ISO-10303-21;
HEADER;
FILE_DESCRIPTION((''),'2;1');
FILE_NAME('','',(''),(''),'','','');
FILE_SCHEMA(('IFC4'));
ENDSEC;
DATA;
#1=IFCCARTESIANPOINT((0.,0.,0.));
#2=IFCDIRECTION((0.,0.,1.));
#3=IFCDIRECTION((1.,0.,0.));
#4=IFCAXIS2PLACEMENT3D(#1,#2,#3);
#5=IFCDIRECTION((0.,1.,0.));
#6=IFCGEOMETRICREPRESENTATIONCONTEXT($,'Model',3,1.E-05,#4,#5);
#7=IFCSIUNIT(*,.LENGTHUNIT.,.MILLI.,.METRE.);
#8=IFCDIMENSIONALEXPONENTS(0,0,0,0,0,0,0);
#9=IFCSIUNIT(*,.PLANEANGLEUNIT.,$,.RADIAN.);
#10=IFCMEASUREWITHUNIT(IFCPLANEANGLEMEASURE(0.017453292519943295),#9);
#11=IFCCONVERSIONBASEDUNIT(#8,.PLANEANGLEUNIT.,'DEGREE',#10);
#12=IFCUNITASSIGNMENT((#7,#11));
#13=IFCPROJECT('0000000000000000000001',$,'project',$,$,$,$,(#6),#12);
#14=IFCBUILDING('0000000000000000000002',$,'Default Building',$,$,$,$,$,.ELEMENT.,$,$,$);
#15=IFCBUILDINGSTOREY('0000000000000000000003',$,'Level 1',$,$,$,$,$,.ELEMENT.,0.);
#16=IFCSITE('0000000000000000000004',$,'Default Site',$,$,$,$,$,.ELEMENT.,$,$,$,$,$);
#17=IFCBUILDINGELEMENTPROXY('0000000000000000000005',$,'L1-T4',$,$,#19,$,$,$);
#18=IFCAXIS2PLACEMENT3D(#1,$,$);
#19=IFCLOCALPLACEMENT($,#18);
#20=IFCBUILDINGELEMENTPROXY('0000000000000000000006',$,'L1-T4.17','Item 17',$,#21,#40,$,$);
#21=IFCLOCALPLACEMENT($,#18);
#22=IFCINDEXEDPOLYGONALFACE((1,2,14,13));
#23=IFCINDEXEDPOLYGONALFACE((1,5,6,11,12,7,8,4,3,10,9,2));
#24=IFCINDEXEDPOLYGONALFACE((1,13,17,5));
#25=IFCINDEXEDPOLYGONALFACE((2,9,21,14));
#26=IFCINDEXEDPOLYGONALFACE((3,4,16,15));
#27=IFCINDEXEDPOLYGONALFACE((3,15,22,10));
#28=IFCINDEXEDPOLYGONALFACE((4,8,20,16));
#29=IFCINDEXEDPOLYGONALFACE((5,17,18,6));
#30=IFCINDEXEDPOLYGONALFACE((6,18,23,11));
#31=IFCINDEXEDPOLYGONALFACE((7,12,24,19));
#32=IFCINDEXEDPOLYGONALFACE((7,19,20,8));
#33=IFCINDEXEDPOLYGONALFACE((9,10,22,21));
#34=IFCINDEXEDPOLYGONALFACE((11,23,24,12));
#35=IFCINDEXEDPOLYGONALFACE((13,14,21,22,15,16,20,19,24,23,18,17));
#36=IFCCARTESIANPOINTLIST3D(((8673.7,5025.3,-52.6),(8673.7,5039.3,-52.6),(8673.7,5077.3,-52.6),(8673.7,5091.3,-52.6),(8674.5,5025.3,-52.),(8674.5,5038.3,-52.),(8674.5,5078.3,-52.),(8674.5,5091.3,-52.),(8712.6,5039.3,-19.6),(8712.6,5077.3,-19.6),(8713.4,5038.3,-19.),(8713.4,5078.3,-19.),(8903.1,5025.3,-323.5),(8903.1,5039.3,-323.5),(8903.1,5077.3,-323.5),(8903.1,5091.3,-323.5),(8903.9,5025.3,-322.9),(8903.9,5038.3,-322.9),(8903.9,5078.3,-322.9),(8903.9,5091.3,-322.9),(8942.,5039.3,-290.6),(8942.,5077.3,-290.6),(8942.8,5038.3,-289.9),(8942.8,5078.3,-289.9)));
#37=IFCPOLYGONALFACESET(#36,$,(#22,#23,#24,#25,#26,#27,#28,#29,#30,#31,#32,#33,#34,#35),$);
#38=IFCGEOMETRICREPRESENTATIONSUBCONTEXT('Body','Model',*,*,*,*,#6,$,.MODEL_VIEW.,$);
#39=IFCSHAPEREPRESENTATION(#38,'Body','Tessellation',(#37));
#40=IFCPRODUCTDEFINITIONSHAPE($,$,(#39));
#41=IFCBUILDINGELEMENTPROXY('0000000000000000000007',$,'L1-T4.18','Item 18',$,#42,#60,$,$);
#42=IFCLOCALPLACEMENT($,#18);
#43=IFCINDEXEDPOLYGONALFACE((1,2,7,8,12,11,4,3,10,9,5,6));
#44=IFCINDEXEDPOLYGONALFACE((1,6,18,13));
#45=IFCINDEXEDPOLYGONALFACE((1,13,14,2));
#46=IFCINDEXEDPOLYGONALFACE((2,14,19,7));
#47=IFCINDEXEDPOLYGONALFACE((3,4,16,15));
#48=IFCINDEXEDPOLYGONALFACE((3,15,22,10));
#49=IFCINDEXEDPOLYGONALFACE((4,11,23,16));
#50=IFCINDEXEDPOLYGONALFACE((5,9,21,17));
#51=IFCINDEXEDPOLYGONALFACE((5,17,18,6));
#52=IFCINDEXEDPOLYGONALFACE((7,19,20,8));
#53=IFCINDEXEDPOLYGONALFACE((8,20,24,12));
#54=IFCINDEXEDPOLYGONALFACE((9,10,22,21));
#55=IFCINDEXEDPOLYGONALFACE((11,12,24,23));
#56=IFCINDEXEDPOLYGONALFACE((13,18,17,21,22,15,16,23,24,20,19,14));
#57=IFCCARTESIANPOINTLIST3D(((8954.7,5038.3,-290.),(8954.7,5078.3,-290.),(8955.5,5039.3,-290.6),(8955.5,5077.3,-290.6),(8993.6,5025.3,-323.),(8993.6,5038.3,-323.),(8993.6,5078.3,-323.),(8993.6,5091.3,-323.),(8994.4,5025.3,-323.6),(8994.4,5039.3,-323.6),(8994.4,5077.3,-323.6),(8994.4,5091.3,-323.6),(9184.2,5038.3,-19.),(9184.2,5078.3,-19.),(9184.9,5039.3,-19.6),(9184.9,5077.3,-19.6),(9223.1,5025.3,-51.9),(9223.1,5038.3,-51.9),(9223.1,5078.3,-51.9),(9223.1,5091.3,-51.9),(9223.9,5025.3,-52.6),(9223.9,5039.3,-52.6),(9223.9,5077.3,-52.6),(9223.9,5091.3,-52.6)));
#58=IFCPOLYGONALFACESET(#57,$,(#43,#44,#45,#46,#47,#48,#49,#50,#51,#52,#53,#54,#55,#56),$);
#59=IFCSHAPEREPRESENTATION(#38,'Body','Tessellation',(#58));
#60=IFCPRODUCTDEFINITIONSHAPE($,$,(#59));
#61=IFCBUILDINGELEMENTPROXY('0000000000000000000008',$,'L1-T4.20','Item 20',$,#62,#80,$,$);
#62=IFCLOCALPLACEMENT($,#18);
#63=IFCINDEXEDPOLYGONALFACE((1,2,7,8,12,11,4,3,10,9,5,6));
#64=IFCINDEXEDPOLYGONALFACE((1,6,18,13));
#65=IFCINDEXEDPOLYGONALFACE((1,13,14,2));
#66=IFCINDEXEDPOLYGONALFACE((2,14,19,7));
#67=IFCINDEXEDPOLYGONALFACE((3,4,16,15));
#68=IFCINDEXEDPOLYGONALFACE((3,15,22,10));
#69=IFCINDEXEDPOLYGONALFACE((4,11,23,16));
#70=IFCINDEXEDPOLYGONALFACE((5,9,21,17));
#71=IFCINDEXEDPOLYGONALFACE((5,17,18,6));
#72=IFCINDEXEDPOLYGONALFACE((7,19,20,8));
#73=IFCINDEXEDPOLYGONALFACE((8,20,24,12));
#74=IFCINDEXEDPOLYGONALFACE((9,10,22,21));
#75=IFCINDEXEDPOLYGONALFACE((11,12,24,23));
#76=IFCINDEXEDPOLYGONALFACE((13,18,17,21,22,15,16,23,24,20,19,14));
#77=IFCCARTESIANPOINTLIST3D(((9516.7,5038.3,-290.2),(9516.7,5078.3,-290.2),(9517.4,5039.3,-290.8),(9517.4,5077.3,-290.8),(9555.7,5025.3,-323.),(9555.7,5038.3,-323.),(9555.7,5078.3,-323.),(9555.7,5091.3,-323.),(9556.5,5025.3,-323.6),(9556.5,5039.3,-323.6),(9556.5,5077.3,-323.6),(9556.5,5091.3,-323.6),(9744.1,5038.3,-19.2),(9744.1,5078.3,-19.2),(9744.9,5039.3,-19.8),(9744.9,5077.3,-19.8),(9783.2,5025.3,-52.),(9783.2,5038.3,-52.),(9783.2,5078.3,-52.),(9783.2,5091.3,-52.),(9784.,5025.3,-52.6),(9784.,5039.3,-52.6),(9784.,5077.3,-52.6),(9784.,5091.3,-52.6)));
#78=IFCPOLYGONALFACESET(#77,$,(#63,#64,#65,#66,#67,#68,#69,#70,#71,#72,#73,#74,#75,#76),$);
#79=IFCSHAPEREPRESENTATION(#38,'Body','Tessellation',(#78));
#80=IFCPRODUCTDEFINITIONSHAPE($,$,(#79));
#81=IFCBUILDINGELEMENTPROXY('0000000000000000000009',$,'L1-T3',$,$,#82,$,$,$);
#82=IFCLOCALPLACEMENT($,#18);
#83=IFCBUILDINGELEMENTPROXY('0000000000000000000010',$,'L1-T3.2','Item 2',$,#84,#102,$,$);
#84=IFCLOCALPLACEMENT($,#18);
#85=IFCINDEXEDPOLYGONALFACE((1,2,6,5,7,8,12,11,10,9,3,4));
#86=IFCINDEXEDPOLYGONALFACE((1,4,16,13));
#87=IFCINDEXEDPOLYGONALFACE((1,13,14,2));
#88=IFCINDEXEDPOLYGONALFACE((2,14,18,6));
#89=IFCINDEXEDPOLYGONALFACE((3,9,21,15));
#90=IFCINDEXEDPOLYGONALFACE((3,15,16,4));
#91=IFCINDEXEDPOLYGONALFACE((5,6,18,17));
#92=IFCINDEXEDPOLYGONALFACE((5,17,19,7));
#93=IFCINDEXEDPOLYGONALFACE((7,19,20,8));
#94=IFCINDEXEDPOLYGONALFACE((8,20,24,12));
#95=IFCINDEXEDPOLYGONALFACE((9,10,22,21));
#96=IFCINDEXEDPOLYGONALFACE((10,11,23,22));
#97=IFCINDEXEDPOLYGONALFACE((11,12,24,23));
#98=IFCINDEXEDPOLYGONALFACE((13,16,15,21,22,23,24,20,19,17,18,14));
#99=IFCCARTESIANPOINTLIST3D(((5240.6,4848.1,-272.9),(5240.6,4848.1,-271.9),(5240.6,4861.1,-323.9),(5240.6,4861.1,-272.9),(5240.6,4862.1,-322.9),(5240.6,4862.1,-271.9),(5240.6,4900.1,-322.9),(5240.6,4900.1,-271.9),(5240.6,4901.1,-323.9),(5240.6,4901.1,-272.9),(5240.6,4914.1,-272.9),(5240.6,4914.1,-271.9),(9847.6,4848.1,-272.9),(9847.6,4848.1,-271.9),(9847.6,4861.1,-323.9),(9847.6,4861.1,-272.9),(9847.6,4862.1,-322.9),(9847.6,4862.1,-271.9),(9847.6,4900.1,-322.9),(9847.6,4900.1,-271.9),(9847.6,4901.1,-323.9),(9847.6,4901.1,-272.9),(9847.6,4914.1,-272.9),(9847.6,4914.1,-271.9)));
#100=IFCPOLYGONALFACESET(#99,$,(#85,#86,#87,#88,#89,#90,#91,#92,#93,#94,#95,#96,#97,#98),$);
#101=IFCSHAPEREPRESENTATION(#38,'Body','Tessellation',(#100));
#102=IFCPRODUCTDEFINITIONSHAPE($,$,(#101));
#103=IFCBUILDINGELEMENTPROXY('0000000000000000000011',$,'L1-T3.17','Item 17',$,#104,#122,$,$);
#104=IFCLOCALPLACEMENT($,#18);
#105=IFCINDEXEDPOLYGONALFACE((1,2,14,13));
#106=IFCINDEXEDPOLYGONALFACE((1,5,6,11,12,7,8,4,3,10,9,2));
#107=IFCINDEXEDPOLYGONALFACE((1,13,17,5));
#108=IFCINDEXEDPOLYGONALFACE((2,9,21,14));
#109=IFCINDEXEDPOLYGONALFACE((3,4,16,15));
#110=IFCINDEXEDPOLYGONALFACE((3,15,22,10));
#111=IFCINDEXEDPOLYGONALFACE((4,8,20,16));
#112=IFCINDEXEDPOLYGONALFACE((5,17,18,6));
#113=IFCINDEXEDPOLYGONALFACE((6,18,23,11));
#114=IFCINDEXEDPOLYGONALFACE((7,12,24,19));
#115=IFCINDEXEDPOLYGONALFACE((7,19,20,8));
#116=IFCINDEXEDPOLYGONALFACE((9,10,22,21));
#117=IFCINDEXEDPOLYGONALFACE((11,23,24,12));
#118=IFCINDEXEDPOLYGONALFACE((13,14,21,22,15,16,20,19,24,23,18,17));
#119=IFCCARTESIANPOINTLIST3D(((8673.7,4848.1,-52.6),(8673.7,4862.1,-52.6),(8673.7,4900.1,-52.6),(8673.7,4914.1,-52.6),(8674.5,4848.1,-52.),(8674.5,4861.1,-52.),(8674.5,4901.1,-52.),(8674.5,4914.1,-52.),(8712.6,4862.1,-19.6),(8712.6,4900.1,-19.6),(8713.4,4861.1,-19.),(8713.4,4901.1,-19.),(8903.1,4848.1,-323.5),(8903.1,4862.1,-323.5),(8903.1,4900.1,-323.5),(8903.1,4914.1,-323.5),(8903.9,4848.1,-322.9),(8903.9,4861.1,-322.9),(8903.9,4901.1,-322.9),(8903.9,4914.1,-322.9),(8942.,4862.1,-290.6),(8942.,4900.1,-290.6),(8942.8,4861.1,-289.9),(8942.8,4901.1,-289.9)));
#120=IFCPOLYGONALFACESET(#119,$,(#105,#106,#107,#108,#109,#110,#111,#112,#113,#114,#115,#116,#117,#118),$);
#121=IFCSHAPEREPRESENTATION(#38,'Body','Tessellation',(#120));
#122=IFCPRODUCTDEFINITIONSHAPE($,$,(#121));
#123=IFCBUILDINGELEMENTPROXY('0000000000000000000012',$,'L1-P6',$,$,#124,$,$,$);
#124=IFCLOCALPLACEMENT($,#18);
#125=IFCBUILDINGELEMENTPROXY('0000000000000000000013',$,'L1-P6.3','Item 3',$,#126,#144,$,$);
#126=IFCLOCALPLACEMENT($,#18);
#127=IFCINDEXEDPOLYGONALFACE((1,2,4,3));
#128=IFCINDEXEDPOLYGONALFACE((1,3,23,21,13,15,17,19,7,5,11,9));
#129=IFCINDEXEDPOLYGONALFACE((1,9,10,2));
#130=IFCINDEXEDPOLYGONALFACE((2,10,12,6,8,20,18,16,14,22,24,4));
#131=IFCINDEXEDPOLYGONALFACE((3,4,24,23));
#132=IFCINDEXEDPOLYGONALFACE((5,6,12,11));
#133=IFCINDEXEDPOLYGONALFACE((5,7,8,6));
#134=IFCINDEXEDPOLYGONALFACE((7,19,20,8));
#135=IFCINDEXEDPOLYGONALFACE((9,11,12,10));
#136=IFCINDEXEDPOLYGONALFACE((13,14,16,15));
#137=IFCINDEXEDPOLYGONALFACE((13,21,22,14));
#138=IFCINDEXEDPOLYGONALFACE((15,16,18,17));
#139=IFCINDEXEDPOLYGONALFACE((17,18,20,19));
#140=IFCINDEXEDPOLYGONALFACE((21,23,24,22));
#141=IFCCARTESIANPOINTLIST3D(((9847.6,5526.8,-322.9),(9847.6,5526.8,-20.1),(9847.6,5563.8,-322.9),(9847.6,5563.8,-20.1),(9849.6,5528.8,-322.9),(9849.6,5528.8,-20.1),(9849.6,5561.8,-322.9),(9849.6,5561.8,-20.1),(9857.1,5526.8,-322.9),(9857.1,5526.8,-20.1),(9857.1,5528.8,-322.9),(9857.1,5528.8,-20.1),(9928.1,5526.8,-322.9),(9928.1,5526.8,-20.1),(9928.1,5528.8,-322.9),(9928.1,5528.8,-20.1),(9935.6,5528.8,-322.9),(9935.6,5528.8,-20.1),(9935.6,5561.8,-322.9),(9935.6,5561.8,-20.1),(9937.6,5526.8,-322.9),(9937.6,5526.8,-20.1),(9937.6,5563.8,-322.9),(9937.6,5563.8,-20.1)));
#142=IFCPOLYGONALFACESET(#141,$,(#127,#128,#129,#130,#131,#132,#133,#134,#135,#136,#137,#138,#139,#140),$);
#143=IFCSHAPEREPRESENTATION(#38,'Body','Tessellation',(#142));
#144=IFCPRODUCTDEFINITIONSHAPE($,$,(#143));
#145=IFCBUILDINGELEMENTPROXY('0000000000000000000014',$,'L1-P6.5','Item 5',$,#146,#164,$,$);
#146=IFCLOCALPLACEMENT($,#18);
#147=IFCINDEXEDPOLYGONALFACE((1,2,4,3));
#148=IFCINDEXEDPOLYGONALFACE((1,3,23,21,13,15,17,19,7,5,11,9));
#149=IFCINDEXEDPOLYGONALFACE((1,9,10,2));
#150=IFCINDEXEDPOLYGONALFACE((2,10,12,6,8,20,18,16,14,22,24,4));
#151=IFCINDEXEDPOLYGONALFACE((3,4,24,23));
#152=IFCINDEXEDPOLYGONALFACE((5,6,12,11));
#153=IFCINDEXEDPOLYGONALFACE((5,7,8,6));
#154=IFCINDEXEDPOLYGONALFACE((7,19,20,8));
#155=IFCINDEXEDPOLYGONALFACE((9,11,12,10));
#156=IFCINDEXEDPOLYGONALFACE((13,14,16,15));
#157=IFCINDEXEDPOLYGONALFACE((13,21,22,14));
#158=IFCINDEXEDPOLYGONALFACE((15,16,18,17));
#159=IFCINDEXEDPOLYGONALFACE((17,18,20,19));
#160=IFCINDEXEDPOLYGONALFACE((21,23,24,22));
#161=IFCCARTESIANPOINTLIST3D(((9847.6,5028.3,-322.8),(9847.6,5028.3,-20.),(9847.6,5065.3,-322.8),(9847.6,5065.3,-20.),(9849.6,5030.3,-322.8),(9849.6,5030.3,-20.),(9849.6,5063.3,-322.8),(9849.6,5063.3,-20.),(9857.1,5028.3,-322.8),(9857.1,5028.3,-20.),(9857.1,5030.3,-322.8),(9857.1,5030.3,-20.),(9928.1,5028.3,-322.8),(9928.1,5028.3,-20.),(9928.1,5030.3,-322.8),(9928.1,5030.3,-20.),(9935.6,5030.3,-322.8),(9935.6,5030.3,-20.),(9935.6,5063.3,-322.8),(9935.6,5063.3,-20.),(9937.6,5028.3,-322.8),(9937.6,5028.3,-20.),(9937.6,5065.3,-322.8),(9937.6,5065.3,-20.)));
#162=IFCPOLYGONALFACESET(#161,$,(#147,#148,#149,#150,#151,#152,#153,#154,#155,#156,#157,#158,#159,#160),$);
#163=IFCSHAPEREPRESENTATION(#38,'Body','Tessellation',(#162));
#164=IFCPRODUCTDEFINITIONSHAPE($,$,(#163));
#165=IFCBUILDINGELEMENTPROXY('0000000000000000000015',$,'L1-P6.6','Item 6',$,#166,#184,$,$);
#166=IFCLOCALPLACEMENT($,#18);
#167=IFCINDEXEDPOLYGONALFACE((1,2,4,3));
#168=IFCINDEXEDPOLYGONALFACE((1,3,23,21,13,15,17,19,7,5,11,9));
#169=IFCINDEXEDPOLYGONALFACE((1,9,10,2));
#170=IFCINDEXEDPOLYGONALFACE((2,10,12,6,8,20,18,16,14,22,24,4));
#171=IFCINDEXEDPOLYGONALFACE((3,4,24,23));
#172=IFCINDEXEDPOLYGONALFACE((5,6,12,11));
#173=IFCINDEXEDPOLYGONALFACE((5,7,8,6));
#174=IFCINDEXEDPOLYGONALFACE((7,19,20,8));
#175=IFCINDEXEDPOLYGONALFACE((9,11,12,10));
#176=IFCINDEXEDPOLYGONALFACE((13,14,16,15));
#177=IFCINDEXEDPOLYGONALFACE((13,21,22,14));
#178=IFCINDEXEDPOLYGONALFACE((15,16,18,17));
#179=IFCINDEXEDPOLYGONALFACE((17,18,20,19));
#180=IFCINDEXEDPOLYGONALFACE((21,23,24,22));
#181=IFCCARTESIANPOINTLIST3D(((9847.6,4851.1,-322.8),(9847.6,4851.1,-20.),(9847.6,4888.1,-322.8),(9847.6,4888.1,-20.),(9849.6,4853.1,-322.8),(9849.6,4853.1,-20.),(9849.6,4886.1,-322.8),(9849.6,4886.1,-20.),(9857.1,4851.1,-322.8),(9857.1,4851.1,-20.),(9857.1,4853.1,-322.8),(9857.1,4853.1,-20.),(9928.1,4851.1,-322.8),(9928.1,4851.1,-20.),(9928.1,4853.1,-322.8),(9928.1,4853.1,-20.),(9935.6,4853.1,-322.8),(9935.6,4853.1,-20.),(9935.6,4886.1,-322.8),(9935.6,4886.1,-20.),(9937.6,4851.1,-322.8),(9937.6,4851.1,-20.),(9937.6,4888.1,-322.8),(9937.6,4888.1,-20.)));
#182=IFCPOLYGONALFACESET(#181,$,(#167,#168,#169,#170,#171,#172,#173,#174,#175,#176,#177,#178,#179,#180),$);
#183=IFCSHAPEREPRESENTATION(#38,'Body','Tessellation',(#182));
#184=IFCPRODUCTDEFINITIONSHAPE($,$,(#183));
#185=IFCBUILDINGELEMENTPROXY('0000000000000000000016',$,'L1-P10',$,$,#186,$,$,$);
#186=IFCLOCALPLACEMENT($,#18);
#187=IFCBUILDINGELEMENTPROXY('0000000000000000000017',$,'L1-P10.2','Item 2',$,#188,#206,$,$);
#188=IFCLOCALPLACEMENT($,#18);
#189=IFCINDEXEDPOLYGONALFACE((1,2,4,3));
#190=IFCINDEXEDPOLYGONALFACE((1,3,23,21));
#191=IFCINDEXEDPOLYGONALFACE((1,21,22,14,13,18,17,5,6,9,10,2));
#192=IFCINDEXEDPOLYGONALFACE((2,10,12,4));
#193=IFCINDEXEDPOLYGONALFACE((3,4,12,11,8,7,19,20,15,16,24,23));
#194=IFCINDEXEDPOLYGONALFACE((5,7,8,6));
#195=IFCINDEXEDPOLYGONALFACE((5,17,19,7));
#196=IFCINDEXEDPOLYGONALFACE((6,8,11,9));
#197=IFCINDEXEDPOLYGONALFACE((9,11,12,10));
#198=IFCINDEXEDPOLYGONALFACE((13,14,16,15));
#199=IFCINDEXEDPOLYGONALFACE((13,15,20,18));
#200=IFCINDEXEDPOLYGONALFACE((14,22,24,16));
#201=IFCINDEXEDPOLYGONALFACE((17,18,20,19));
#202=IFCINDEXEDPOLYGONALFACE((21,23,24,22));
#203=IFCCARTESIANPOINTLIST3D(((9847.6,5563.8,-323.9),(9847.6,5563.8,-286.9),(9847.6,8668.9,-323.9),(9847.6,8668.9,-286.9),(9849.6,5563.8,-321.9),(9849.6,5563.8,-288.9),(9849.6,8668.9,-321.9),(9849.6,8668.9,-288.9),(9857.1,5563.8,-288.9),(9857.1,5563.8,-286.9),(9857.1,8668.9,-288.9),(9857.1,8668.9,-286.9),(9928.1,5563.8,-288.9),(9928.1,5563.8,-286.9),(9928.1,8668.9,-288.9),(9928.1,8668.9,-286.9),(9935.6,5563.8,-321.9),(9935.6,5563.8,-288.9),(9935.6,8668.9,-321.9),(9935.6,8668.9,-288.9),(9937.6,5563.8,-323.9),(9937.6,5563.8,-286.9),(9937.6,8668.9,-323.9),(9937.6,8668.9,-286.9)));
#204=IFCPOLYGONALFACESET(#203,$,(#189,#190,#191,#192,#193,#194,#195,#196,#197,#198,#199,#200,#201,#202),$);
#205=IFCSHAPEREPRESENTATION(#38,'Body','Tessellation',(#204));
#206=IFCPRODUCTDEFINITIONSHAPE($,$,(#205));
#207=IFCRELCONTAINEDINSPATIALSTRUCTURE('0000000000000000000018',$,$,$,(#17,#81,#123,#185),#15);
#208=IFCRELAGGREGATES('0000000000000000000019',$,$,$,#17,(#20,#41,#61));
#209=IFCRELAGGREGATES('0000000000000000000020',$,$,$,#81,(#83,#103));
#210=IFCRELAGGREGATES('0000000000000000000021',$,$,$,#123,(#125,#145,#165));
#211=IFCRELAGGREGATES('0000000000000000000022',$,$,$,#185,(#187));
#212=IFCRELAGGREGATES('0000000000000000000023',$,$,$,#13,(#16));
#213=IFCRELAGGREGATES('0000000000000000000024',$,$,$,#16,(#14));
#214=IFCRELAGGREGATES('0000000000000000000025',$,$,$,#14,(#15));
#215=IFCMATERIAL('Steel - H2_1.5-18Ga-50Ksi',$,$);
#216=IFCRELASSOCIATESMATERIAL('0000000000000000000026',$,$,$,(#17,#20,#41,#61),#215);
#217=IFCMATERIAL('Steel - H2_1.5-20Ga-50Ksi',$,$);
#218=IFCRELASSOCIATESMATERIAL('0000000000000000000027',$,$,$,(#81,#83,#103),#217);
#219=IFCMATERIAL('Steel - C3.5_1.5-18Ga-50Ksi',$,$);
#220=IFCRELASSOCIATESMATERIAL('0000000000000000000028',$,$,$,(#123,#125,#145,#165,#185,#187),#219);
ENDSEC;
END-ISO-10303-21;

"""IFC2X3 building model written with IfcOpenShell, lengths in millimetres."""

from ifc_helpers import new_model, entity, si_unit, converted_unit, direction, frame, origin, origin_with_axes, origin_2d_with_axis, place, context, subcontext, project, spatial, polyline, c_section, outline, extrude, material, element, aggregate, save


model = new_model("IFC2X3")

# Units and contexts
model_context = context("Model", 3, precision=1e-05, world=origin_with_axes(), true_north=direction((0.0, 1.0, 0.0)))
body_context = subcontext(model_context, "Body", "Model", "MODEL_VIEW")
ifc_project = project(units=[si_unit("LENGTHUNIT", "METRE", prefix="MILLI"), converted_unit("PLANEANGLEUNIT", "DEGREE", entity("IfcPlaneAngleMeasure", 0.017453292519943295), si_unit("PLANEANGLEUNIT", "RADIAN"), dimensions=[0, 0, 0, 0, 0, 0, 0])], contexts=[model_context])

# Site, building, storey
site = spatial("IfcSite", under=ifc_project, Name="Default Site", CompositionType="ELEMENT")
building = spatial("IfcBuilding", under=site, Name="Default Building", CompositionType="ELEMENT")
storey = spatial("IfcBuildingStorey", under=building, Name="Level 1", CompositionType="ELEMENT", Elevation=0.0)

# Building element proxies
ifc_material_1 = material(Name="Steel - H2_1.5-20Ga-50Ksi")
ifc_material_2 = material(Name="Steel - H2_1.5-18Ga-50Ksi")
proxy_1 = element("IfcBuildingElementProxy", 1, inside=storey, material=ifc_material_2, Name="L1-T4")
proxy_2_placement = place(None, frame((8673.7, 5025.3, -52.6), z_axis=(0.646, 0.0, -0.763), x_axis=(0.0, 40.0, 0.0)))
proxy_2 = element("IfcBuildingElementProxy", 2, at=proxy_2_placement, material=ifc_material_2, Name="L1-T4.17", Description="Item 17", context=body_context, shape_type="SweptSolid", body=[
    extrude(outline(polyline([(0.0, 0.0), (14.0, 0.0), (14.0, 51.0), (52.0, 51.0), (52.0, 0.0), (66.0, 0.0), (66.0, 1.0), (53.0, 1.0), (53.0, 52.0), (13.0, 52.0), (13.0, 1.0), (0.0, 1.0), (0.0, 0.0)])), origin(), (0.0, 0.0, 1.0), 355.0),
])
proxy_3_placement = place(None, frame((8994.4, 5025.3, -323.6), z_axis=(0.646, 0.0, 0.763), x_axis=(0.0, 40.0, 0.0)))
proxy_3 = element("IfcBuildingElementProxy", 3, at=proxy_3_placement, material=ifc_material_2, Name="L1-T4.18", Description="Item 18", context=body_context, shape_type="SweptSolid", body=[
    extrude(outline(polyline([(0.0, 0.0), (14.0, 0.0), (14.0, 51.0), (52.0, 51.0), (52.0, 0.0), (66.0, 0.0), (66.0, 1.0), (53.0, 1.0), (53.0, 52.0), (13.0, 52.0), (13.0, 1.0), (0.0, 1.0), (0.0, 0.0)])), origin(), (0.0, 0.0, 1.0), 355.1),
])
proxy_4_placement = place(None, frame((9556.5, 5025.3, -323.6), z_axis=(0.643, 0.0, 0.766), x_axis=(0.0, 40.0, 0.0)))
proxy_4 = element("IfcBuildingElementProxy", 4, at=proxy_4_placement, material=ifc_material_2, Name="L1-T4.20", Description="Item 20", context=body_context, shape_type="SweptSolid", body=[
    extrude(outline(polyline([(0.0, 0.0), (14.0, 0.0), (14.0, 51.0), (52.0, 51.0), (52.0, 0.0), (66.0, 0.0), (66.0, 1.0), (53.0, 1.0), (53.0, 52.0), (13.0, 52.0), (13.0, 1.0), (0.0, 1.0), (0.0, 0.0)])), origin(), (0.0, 0.0, 1.0), 353.8),
])
aggregate(proxy_1, [proxy_2, proxy_3, proxy_4])
proxy_5 = element("IfcBuildingElementProxy", 5, inside=storey, material=ifc_material_1, Name="L1-T3")
proxy_6_placement = place(None, frame((9847.6, 4848.1, -271.9), z_axis=(-1.0, 0.0, 0.0), x_axis=(0.0, 40.0, 0.0)))
proxy_6 = element("IfcBuildingElementProxy", 6, at=proxy_6_placement, material=ifc_material_1, Name="L1-T3.2", Description="Item 2", context=body_context, shape_type="SweptSolid", body=[
    extrude(outline(polyline([(0.0, 0.0), (14.0, 0.0), (14.0, 51.0), (52.0, 51.0), (52.0, 0.0), (66.0, 0.0), (66.0, 1.0), (53.0, 1.0), (53.0, 52.0), (13.0, 52.0), (13.0, 1.0), (0.0, 1.0), (0.0, 0.0)])), origin(), (0.0, 0.0, 1.0), 4607.0),
])
proxy_7_placement = place(None, frame((8673.7, 4848.1, -52.6), z_axis=(0.646, 0.0, -0.763), x_axis=(0.0, 40.0, 0.0)))
proxy_7 = element("IfcBuildingElementProxy", 7, at=proxy_7_placement, material=ifc_material_1, Name="L1-T3.17", Description="Item 17", context=body_context, shape_type="SweptSolid", body=[
    extrude(outline(polyline([(0.0, 0.0), (14.0, 0.0), (14.0, 51.0), (52.0, 51.0), (52.0, 0.0), (66.0, 0.0), (66.0, 1.0), (53.0, 1.0), (53.0, 52.0), (13.0, 52.0), (13.0, 1.0), (0.0, 1.0), (0.0, 0.0)])), origin(), (0.0, 0.0, 1.0), 355.0),
])
aggregate(proxy_5, [proxy_6, proxy_7])
ifc_material_3 = material(Name="Steel - C3.5_1.5-18Ga-50Ksi")
proxy_8 = element("IfcBuildingElementProxy", 8, inside=storey, material=ifc_material_3, Name="L1-P6")
proxy_9_placement = place(None, frame((9892.6, 5545.3, -322.9), z_axis=(0.0, 0.0, 1.0), x_axis=(0.0, -37.0, 0.0)))
proxy_9 = element("IfcBuildingElementProxy", 9, at=proxy_9_placement, material=ifc_material_3, Name="L1-P6.3", Description="Item 3", context=body_context, shape_type="SweptSolid", body=[
    extrude(c_section(Depth=90.0, Width=37.0, WallThickness=2.0, Girth=9.5, at=origin_2d_with_axis()), origin(), (0.0, 0.0, 1.0), 302.8),
])
proxy_10_placement = place(None, frame((9892.6, 5046.8, -322.8), z_axis=(0.0, 0.0, 1.0), x_axis=(0.0, -37.0, 0.0)))
proxy_10 = element("IfcBuildingElementProxy", 10, at=proxy_10_placement, material=ifc_material_3, Name="L1-P6.5", Description="Item 5", context=body_context, shape_type="SweptSolid", body=[
    extrude(c_section(Depth=90.0, Width=37.0, WallThickness=2.0, Girth=9.5, at=origin_2d_with_axis()), origin(), (0.0, 0.0, 1.0), 302.8),
])
proxy_11_placement = place(None, frame((9892.6, 4869.6, -322.8), z_axis=(0.0, 0.0, 1.0), x_axis=(0.0, -37.0, 0.0)))
proxy_11 = element("IfcBuildingElementProxy", 11, at=proxy_11_placement, material=ifc_material_3, Name="L1-P6.6", Description="Item 6", context=body_context, shape_type="SweptSolid", body=[
    extrude(c_section(Depth=90.0, Width=37.0, WallThickness=2.0, Girth=9.5, at=origin_2d_with_axis()), origin(), (0.0, 0.0, 1.0), 302.8),
])
aggregate(proxy_8, [proxy_9, proxy_10, proxy_11])
proxy_12 = element("IfcBuildingElementProxy", 12, inside=storey, material=ifc_material_3, Name="L1-P10")
proxy_13_placement = place(None, frame((9892.6, 5563.8, -305.4), z_axis=(0.0, 1.0, 0.0), x_axis=(0.0, 0.0, 37.0)))
proxy_13 = element("IfcBuildingElementProxy", 13, at=proxy_13_placement, material=ifc_material_3, Name="L1-P10.2", Description="Item 2", context=body_context, shape_type="SweptSolid", body=[
    extrude(c_section(Depth=90.0, Width=37.0, WallThickness=2.0, Girth=9.5, at=origin_2d_with_axis()), origin(), (0.0, 0.0, 1.0), 3105.1),
])
aggregate(proxy_12, [proxy_13])

save(model, "model.ifc")
